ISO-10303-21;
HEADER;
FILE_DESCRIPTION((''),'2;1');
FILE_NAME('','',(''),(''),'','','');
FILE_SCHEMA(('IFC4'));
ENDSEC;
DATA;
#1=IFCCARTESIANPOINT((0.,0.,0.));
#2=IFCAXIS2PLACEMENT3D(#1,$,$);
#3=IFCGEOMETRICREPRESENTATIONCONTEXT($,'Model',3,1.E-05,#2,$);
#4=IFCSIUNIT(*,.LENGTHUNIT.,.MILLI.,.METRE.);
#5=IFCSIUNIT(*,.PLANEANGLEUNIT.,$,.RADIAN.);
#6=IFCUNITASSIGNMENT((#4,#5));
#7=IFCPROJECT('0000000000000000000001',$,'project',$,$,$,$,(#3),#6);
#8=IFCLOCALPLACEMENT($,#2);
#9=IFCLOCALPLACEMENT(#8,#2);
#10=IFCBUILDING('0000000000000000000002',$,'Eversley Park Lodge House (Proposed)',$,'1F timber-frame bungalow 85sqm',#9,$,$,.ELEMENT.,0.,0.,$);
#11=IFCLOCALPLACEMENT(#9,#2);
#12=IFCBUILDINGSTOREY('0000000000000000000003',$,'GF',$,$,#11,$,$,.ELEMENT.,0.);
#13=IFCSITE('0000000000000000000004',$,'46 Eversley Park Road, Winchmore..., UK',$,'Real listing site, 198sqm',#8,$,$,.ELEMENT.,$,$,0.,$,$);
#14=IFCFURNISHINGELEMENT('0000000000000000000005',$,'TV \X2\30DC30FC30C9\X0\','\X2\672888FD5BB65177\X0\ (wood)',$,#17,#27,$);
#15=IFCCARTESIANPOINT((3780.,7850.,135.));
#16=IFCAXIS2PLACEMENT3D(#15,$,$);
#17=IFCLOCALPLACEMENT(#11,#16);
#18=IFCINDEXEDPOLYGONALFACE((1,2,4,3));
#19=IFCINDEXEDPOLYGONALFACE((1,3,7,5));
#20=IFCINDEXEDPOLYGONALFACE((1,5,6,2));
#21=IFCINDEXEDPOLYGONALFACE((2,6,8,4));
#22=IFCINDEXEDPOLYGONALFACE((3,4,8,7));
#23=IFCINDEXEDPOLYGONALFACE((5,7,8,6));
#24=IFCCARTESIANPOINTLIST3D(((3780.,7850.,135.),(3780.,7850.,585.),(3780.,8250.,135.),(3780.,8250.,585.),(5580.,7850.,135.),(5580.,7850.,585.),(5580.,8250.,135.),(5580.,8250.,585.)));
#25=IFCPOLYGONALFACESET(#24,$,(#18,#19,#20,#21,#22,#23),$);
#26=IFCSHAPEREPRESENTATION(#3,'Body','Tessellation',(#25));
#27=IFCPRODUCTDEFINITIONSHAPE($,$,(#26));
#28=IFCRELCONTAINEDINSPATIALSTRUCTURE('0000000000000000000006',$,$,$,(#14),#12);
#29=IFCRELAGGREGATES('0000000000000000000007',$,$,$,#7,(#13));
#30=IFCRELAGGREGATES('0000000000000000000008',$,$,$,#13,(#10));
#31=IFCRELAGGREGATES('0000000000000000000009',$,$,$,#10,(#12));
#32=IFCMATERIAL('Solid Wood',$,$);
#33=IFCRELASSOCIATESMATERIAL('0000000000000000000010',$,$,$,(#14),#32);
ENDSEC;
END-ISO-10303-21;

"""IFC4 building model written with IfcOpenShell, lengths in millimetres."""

from ifc_helpers import new_model, si_unit, frame, frame_2d, origin, place, context, project, spatial, rectangle, extrude, material, element, save


model = new_model("IFC4")

# Units and contexts
model_context = context("Model", 3, precision=1e-05, world=origin())
ifc_project = project(units=[si_unit("LENGTHUNIT", "METRE", prefix="MILLI"), si_unit("PLANEANGLEUNIT", "RADIAN")], contexts=[model_context])

# Site, building, storey
site_placement = place(None, origin())
site = spatial("IfcSite", under=ifc_project, at=site_placement, Name="46 Eversley Park Road, Winchmore..., UK", ObjectType="Real listing site, 198sqm", CompositionType="ELEMENT", RefElevation=0.0)
building_placement = place(site_placement, origin())
building = spatial("IfcBuilding", under=site, at=building_placement, Name="Eversley Park Lodge House (Proposed)", ObjectType="1F timber-frame bungalow 85sqm", CompositionType="ELEMENT", ElevationOfRefHeight=0.0, ElevationOfTerrain=0.0)
storey_placement = place(building_placement, origin())
storey = spatial("IfcBuildingStorey", under=building, at=storey_placement, Name="GF", CompositionType="ELEMENT", Elevation=0.0)

# Shared definitions
ifc_material_1 = material(Name="Solid Wood")

# Furnishing element
furnishing_1_placement = place(storey_placement, frame((3780.0, 7850.0, 135.0)))
element("IfcFurnishingElement", 1, at=furnishing_1_placement, inside=storey, material=ifc_material_1, Name="TV ボード", Description="木製家具 (wood)", context=model_context, shape_type="SweptSolid", body=[
    extrude(rectangle(XDim=1800.0, YDim=400.0, at=frame_2d((900.0, 200.0))), frame((3780.0, 7850.0, 135.0)), (0.0, 0.0, 1.0), 450.0),
])

save(model, "model.ifc")
